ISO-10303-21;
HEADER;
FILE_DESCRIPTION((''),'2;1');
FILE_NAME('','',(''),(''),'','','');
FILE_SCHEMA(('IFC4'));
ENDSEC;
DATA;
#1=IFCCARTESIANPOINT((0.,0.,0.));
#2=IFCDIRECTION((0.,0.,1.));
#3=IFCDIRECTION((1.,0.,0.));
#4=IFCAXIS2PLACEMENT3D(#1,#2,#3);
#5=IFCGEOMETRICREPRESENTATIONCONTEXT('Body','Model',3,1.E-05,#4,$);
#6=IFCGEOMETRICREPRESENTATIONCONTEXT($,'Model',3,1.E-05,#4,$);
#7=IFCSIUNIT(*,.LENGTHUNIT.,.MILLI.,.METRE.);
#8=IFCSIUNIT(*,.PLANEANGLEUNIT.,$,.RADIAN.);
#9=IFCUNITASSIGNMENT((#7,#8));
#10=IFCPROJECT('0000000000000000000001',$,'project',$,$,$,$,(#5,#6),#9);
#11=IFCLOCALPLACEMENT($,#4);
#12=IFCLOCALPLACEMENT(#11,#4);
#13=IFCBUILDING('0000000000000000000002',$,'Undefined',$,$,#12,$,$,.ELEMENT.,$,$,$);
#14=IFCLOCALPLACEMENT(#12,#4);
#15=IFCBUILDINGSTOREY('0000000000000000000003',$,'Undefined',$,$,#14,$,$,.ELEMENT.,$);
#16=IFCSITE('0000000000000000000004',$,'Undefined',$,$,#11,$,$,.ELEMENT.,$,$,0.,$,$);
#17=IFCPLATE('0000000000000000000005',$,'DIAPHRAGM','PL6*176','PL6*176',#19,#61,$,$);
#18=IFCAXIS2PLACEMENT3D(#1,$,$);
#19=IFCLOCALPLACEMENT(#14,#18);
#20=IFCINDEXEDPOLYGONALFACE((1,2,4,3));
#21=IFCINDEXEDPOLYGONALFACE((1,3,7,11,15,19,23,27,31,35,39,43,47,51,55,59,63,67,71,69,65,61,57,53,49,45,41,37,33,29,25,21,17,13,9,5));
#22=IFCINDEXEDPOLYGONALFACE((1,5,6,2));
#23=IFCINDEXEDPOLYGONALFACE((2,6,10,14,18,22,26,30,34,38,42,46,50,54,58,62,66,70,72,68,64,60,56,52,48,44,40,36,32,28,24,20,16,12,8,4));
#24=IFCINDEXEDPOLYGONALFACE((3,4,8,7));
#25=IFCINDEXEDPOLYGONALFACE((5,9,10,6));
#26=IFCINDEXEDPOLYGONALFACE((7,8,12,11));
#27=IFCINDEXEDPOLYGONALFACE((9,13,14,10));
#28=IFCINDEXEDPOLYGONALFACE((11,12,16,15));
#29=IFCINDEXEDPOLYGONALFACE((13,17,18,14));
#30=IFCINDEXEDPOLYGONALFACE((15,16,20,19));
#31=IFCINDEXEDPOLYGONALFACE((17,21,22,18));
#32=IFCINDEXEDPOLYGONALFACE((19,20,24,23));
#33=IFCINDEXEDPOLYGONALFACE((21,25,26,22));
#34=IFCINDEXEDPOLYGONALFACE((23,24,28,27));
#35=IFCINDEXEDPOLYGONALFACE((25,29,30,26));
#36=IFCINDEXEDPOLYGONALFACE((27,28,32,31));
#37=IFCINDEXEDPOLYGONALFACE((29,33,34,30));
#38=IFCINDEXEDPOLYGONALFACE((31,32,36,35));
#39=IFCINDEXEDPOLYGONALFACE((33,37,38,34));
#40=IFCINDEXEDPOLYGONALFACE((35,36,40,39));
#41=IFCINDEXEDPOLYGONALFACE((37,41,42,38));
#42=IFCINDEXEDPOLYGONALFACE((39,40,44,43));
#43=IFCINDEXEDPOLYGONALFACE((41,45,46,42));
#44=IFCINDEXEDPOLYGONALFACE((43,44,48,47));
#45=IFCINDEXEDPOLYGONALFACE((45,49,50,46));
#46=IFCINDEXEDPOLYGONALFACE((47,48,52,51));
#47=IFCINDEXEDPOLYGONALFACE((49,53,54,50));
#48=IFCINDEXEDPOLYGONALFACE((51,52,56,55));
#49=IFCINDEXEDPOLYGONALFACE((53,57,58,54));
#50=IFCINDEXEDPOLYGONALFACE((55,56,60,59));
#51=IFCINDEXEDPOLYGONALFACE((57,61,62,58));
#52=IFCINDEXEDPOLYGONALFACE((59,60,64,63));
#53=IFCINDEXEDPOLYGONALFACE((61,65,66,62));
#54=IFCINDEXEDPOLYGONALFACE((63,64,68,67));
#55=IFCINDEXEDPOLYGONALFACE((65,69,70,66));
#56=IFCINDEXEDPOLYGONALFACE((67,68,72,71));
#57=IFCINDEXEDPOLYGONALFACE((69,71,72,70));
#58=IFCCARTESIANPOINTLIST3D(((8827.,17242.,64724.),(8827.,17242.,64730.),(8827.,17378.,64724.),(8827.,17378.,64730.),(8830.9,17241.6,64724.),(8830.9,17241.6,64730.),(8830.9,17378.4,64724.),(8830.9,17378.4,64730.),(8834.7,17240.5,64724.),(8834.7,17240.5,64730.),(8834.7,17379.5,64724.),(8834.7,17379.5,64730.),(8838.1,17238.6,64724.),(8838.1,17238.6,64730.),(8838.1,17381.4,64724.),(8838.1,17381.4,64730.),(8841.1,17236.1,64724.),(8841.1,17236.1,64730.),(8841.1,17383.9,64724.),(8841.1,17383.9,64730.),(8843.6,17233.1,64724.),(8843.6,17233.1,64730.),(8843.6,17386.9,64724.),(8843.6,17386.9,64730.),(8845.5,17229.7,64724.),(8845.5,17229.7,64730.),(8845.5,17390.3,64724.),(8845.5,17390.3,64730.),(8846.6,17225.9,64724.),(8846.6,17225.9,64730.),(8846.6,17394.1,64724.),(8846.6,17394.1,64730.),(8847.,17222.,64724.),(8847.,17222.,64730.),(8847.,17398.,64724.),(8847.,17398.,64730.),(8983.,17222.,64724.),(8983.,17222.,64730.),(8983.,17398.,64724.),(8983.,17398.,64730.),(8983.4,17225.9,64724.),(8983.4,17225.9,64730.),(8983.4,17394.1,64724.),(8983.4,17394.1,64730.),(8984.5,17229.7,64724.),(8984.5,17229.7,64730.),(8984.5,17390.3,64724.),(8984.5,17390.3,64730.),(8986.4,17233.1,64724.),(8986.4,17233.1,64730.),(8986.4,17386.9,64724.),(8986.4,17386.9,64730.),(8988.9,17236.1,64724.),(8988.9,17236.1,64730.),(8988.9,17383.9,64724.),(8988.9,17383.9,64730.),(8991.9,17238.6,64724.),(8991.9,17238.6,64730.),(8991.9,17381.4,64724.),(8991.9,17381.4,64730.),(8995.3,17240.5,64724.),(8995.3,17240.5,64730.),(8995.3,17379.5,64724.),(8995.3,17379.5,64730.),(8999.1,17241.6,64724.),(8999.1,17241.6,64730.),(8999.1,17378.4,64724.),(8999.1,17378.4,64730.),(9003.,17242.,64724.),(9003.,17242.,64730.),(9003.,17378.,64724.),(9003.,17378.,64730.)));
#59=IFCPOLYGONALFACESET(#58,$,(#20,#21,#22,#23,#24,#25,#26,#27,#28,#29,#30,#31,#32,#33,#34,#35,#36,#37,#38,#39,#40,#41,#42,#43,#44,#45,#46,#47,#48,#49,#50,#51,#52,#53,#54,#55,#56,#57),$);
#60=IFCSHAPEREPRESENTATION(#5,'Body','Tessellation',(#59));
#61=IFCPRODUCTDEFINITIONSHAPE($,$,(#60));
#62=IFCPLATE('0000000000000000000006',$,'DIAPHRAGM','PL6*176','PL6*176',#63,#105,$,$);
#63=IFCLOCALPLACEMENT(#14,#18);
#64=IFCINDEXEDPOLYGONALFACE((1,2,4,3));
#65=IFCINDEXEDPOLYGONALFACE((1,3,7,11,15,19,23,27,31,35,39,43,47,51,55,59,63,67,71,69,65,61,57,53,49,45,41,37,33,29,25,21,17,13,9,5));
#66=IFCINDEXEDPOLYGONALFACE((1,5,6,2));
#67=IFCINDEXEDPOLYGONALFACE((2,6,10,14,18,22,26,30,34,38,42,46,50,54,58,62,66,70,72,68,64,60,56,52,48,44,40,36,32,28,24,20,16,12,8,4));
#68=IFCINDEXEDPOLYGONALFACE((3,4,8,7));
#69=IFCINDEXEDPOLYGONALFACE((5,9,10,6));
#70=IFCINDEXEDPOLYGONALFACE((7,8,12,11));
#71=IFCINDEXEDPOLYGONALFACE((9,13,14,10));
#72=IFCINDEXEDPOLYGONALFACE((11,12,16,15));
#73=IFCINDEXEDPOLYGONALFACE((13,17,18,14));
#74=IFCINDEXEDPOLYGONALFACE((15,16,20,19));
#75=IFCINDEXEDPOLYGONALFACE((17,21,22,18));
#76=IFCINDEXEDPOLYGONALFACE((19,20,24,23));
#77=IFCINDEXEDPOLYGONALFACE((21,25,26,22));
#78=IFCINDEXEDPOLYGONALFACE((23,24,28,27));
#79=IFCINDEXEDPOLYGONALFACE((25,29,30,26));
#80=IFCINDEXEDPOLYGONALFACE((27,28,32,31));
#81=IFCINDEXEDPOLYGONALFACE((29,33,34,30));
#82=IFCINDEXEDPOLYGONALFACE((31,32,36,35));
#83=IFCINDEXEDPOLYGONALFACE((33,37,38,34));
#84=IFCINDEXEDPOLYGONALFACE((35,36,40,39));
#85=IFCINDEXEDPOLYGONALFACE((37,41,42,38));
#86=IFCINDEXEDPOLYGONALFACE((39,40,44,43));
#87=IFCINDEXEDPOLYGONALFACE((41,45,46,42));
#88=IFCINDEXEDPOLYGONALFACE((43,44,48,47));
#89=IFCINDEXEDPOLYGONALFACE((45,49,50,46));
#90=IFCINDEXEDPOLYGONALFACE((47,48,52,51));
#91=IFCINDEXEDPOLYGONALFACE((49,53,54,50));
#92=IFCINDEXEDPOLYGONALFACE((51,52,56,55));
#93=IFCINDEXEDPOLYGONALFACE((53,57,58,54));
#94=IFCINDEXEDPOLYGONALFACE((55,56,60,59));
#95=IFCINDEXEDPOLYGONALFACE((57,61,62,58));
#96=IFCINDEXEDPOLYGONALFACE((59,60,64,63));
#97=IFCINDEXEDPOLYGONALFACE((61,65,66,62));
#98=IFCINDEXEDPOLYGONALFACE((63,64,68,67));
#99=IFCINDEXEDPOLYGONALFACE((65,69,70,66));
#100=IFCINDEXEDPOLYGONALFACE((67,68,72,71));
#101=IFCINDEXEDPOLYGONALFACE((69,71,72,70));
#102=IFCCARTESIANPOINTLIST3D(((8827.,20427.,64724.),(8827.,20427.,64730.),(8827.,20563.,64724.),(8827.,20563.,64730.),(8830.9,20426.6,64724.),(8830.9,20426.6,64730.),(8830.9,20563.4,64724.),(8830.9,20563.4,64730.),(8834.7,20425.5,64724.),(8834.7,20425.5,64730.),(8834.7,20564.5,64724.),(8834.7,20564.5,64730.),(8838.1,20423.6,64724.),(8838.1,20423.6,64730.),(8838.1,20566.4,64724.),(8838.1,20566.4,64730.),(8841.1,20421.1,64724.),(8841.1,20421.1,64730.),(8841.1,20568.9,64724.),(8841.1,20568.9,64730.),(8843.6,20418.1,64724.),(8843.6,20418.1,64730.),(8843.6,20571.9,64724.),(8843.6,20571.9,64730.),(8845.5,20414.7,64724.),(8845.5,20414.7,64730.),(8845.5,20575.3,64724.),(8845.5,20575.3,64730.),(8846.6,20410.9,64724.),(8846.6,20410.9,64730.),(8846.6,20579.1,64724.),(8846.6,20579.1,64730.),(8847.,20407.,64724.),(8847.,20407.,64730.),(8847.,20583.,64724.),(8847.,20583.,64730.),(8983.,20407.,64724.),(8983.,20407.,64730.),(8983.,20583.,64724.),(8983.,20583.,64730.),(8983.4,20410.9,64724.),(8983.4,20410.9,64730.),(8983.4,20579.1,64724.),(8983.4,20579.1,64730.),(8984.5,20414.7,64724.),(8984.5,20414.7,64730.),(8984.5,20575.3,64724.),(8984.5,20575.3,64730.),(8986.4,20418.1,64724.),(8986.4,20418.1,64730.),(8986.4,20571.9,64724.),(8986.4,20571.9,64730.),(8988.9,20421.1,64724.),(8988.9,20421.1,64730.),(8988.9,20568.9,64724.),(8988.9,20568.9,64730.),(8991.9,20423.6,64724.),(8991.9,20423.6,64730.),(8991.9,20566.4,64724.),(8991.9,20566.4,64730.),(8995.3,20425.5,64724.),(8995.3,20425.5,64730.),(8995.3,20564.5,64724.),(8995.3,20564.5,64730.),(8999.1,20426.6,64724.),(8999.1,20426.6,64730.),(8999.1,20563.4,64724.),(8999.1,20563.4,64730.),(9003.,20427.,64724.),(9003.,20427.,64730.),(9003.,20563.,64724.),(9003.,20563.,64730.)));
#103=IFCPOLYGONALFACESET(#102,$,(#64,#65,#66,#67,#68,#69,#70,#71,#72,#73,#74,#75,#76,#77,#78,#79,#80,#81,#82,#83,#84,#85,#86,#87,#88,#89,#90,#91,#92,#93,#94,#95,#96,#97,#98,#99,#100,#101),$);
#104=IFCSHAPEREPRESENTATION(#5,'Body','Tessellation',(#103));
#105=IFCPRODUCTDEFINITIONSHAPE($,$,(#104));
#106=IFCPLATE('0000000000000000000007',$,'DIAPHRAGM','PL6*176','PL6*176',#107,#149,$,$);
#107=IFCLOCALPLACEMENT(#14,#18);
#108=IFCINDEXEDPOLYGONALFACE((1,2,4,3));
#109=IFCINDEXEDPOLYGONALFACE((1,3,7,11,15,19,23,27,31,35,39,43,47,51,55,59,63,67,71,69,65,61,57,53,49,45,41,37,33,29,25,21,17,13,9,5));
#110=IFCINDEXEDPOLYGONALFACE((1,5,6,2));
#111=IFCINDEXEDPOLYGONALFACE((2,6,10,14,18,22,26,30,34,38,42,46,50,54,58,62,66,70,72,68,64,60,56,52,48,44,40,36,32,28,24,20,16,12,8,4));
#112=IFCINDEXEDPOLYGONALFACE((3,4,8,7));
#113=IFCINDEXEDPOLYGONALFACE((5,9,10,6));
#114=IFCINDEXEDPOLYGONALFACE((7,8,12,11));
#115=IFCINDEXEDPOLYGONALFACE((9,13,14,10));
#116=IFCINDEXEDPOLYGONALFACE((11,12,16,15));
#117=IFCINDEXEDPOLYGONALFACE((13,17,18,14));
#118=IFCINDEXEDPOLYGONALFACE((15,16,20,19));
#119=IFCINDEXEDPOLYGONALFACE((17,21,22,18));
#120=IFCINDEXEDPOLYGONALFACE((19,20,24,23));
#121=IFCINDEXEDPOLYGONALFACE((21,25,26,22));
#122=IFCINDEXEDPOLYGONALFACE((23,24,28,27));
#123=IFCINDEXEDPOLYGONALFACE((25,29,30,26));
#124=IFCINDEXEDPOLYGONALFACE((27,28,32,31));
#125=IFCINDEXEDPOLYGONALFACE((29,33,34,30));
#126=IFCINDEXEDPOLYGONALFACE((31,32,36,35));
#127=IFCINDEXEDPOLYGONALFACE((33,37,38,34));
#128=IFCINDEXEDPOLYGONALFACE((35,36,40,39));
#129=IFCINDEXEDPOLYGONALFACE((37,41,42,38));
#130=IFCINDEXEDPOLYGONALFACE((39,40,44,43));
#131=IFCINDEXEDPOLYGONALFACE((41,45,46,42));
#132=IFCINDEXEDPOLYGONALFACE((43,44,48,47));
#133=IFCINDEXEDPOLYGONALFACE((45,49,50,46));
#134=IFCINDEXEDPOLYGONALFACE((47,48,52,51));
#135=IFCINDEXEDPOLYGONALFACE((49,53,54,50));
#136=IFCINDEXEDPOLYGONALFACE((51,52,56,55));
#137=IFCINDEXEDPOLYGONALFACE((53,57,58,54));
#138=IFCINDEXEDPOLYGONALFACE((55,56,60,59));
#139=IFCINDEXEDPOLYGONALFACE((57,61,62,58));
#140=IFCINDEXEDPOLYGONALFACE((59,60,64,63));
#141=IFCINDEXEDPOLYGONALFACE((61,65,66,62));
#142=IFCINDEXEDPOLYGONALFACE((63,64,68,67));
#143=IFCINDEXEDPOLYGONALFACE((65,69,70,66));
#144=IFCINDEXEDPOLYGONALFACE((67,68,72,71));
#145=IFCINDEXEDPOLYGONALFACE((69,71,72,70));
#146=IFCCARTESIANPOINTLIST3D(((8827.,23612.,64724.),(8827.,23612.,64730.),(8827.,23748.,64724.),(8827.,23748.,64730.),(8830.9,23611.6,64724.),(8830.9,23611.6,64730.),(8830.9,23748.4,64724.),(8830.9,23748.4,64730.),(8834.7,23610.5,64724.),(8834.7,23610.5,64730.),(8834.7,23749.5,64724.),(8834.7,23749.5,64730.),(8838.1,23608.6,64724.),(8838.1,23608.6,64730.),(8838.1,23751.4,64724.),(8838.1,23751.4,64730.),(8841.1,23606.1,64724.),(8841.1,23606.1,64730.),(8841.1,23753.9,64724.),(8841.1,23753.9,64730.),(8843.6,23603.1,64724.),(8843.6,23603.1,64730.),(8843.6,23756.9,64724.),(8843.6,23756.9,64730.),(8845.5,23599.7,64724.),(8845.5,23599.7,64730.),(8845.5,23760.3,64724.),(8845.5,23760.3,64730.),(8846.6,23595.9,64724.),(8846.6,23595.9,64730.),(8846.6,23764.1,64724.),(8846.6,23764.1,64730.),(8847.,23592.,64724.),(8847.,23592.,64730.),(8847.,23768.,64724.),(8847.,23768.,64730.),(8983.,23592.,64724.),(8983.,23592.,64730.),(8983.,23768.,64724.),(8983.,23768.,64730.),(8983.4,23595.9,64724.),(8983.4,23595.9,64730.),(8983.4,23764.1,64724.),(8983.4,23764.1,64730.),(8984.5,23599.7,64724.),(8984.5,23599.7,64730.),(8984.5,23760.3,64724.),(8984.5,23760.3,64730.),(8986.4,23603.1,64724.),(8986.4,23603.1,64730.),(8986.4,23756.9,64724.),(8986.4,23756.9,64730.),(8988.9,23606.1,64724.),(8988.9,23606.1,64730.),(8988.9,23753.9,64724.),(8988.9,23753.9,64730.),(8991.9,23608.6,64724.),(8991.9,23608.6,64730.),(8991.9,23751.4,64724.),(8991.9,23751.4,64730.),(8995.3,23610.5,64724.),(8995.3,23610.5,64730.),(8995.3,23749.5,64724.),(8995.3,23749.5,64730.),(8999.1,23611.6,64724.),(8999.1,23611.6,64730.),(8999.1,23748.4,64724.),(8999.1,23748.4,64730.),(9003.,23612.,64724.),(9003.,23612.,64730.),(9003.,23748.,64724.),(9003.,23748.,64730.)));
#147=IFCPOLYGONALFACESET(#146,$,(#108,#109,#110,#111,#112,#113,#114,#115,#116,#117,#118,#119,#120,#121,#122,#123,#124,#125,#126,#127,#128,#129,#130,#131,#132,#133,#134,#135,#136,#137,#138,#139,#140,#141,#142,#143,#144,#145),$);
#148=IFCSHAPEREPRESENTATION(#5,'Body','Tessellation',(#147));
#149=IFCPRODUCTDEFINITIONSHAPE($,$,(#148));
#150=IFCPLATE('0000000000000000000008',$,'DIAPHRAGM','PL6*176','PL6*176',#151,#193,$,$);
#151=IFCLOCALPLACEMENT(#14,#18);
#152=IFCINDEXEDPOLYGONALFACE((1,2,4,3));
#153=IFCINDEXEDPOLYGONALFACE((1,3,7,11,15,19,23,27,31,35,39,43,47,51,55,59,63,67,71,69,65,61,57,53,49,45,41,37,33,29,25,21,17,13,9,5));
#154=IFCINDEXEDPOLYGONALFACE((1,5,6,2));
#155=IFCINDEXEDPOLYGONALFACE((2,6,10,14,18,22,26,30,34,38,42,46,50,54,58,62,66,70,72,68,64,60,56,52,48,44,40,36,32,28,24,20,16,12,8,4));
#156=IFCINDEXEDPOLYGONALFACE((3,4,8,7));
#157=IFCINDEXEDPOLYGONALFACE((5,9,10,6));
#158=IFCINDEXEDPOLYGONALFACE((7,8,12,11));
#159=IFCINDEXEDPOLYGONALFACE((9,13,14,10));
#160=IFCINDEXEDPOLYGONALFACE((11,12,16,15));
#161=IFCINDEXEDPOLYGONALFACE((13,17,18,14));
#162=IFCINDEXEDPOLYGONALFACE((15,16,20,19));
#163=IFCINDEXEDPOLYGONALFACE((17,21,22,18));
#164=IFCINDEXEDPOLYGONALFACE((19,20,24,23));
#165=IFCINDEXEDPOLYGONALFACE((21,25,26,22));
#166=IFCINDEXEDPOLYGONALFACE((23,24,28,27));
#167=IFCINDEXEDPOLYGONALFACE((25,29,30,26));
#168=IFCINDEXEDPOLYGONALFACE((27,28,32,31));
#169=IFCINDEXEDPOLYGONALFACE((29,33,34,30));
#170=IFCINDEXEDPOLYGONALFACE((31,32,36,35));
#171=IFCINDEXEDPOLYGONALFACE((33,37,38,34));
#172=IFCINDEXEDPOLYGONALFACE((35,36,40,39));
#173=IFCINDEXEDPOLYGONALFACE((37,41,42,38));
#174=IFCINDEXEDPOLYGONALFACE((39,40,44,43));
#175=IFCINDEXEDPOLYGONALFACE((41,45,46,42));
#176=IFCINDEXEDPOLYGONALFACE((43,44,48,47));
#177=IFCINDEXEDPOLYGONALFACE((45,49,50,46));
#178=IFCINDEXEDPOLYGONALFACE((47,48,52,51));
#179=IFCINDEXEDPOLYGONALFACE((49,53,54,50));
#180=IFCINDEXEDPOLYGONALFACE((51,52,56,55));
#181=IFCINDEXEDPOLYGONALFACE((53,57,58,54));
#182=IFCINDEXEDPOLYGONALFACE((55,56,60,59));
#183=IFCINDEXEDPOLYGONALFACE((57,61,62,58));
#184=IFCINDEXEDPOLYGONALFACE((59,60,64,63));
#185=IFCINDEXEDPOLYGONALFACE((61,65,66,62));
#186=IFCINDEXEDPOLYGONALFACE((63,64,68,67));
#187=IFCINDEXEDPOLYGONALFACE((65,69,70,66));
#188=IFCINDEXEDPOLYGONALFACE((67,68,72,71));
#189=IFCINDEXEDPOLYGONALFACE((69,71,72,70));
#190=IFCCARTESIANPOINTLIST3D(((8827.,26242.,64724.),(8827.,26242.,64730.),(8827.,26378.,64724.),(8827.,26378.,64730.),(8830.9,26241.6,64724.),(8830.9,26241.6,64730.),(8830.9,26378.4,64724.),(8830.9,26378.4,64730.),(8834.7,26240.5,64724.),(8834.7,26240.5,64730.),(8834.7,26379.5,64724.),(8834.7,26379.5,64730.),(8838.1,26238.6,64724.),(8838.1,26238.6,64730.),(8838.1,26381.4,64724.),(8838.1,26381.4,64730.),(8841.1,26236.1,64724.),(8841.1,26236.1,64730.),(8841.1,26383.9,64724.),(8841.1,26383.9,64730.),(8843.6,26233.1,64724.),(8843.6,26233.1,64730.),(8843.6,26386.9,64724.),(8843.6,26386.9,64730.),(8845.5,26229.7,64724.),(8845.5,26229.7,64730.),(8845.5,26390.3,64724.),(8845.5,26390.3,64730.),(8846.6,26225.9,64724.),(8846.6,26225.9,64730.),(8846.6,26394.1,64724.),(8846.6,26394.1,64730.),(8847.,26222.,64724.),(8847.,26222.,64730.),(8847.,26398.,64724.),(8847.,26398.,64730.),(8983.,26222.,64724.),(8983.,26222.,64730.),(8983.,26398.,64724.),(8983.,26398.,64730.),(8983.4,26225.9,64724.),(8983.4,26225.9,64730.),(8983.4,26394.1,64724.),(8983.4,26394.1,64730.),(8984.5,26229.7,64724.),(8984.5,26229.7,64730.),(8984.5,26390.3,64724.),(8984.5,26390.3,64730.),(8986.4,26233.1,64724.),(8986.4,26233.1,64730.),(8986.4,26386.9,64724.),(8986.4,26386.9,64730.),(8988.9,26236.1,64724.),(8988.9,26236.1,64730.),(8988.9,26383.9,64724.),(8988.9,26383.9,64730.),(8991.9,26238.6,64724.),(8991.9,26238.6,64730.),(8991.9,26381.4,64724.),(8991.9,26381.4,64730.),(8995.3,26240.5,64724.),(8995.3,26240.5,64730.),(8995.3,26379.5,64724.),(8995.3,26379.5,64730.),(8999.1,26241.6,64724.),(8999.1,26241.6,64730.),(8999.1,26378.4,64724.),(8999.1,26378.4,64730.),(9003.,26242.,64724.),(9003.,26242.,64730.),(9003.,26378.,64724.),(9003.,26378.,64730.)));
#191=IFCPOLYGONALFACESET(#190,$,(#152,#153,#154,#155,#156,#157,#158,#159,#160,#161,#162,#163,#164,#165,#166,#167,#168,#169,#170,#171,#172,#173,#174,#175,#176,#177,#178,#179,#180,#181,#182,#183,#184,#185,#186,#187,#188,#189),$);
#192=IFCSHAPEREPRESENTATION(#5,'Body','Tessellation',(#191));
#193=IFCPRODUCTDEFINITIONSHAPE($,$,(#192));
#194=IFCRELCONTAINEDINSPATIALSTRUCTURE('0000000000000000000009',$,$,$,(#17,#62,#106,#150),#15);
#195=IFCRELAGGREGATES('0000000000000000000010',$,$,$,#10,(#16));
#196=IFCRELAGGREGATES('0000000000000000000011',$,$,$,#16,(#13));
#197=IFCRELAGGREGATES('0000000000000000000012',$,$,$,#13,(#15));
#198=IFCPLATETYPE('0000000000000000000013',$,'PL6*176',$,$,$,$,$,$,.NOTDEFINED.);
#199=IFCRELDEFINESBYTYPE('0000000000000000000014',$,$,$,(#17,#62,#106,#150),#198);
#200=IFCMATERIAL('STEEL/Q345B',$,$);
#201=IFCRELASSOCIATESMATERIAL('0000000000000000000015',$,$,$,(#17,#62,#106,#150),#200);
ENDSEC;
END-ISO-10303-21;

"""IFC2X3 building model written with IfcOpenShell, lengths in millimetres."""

from ifc_helpers import new_model, si_unit, frame, origin_with_axes, place, context, project, spatial, polyline, outline, extrude, material, type_object, element, save


model = new_model("IFC2X3")

# Units and contexts
model_context_1 = context("Model", 3, precision=1e-05, world=origin_with_axes(), identifier="Body")
model_context_2 = context("Model", 3, precision=1e-05, world=origin_with_axes())
ifc_project = project(units=[si_unit("LENGTHUNIT", "METRE", prefix="MILLI"), si_unit("PLANEANGLEUNIT", "RADIAN")], contexts=[model_context_1, model_context_2])

# Site, building, storey
site_placement = place(None, origin_with_axes())
site = spatial("IfcSite", under=ifc_project, at=site_placement, Name="Undefined", CompositionType="ELEMENT", RefElevation=0.0)
building_placement = place(site_placement, origin_with_axes())
building = spatial("IfcBuilding", under=site, at=building_placement, Name="Undefined", CompositionType="ELEMENT")
storey_placement = place(building_placement, origin_with_axes())
storey = spatial("IfcBuildingStorey", under=building, at=storey_placement, Name="Undefined", CompositionType="ELEMENT")

# Shared definitions
ifc_material_1 = material(Name="STEEL/Q345B")

# Plates
plate_type_1 = type_object("IfcPlateType", Name="PL6*176", PredefinedType="NOTDEFINED")
for number, where, z_axis, x_axis, name in (
    (1, (9003.0, 17222.0, 64727.0), (0.0, 0.0, -1.0), (-1.0, 0.0, 0.0), "DIAPHRAGM"),
    (2, (9003.0, 20407.0, 64727.0), (0.0, 0.0, -1.0), (-1.0, 0.0, 0.0), "DIAPHRAGM"),
    (3, (9003.0, 23592.0, 64727.0), (0.0, 0.0, -1.0), (-1.0, 0.0, 0.0), "DIAPHRAGM"),
    (4, (9003.0, 26222.0, 64727.0), (0.0, 0.0, -1.0), (-1.0, 0.0, 0.0), "DIAPHRAGM"),
):
    element("IfcPlate", number, at=place(storey_placement, frame(where, z_axis=z_axis, x_axis=x_axis)), inside=storey, type_object=plate_type_1, material=ifc_material_1, Name=name, Description="PL6*176", ObjectType="PL6*176", context=model_context_1, shape_type="SweptSolid", body=[
        extrude(outline(polyline([(0.0, 20.0), (3.9, 19.6), (7.7, 18.5), (11.1, 16.6), (14.1, 14.1), (16.6, 11.1), (18.5, 7.7), (19.6, 3.9), (20.0, 0.0), (156.0, 0.0), (156.4, 3.9), (157.5, 7.7), (159.4, 11.1), (161.9, 14.1), (164.9, 16.6), (168.3, 18.5), (172.1, 19.6), (176.0, 20.0), (176.0, 156.0), (172.1, 156.4), (168.3, 157.5), (164.9, 159.4), (161.9, 161.9), (159.4, 164.9), (157.5, 168.3), (156.4, 172.1), (156.0, 176.0), (20.0, 176.0), (19.6, 172.1), (18.5, 168.3), (16.6, 164.9), (14.1, 161.9), (11.1, 159.4), (7.7, 157.5), (3.9, 156.4), (0.0, 156.0), (0.0, 20.0)])), frame((0.0, 0.0, -3.0), z_axis=(0.0, 0.0, 1.0), x_axis=(1.0, 0.0, 0.0)), (0.0, 0.0, 1.0), 6.0),
    ])

save(model, "model.ifc")
